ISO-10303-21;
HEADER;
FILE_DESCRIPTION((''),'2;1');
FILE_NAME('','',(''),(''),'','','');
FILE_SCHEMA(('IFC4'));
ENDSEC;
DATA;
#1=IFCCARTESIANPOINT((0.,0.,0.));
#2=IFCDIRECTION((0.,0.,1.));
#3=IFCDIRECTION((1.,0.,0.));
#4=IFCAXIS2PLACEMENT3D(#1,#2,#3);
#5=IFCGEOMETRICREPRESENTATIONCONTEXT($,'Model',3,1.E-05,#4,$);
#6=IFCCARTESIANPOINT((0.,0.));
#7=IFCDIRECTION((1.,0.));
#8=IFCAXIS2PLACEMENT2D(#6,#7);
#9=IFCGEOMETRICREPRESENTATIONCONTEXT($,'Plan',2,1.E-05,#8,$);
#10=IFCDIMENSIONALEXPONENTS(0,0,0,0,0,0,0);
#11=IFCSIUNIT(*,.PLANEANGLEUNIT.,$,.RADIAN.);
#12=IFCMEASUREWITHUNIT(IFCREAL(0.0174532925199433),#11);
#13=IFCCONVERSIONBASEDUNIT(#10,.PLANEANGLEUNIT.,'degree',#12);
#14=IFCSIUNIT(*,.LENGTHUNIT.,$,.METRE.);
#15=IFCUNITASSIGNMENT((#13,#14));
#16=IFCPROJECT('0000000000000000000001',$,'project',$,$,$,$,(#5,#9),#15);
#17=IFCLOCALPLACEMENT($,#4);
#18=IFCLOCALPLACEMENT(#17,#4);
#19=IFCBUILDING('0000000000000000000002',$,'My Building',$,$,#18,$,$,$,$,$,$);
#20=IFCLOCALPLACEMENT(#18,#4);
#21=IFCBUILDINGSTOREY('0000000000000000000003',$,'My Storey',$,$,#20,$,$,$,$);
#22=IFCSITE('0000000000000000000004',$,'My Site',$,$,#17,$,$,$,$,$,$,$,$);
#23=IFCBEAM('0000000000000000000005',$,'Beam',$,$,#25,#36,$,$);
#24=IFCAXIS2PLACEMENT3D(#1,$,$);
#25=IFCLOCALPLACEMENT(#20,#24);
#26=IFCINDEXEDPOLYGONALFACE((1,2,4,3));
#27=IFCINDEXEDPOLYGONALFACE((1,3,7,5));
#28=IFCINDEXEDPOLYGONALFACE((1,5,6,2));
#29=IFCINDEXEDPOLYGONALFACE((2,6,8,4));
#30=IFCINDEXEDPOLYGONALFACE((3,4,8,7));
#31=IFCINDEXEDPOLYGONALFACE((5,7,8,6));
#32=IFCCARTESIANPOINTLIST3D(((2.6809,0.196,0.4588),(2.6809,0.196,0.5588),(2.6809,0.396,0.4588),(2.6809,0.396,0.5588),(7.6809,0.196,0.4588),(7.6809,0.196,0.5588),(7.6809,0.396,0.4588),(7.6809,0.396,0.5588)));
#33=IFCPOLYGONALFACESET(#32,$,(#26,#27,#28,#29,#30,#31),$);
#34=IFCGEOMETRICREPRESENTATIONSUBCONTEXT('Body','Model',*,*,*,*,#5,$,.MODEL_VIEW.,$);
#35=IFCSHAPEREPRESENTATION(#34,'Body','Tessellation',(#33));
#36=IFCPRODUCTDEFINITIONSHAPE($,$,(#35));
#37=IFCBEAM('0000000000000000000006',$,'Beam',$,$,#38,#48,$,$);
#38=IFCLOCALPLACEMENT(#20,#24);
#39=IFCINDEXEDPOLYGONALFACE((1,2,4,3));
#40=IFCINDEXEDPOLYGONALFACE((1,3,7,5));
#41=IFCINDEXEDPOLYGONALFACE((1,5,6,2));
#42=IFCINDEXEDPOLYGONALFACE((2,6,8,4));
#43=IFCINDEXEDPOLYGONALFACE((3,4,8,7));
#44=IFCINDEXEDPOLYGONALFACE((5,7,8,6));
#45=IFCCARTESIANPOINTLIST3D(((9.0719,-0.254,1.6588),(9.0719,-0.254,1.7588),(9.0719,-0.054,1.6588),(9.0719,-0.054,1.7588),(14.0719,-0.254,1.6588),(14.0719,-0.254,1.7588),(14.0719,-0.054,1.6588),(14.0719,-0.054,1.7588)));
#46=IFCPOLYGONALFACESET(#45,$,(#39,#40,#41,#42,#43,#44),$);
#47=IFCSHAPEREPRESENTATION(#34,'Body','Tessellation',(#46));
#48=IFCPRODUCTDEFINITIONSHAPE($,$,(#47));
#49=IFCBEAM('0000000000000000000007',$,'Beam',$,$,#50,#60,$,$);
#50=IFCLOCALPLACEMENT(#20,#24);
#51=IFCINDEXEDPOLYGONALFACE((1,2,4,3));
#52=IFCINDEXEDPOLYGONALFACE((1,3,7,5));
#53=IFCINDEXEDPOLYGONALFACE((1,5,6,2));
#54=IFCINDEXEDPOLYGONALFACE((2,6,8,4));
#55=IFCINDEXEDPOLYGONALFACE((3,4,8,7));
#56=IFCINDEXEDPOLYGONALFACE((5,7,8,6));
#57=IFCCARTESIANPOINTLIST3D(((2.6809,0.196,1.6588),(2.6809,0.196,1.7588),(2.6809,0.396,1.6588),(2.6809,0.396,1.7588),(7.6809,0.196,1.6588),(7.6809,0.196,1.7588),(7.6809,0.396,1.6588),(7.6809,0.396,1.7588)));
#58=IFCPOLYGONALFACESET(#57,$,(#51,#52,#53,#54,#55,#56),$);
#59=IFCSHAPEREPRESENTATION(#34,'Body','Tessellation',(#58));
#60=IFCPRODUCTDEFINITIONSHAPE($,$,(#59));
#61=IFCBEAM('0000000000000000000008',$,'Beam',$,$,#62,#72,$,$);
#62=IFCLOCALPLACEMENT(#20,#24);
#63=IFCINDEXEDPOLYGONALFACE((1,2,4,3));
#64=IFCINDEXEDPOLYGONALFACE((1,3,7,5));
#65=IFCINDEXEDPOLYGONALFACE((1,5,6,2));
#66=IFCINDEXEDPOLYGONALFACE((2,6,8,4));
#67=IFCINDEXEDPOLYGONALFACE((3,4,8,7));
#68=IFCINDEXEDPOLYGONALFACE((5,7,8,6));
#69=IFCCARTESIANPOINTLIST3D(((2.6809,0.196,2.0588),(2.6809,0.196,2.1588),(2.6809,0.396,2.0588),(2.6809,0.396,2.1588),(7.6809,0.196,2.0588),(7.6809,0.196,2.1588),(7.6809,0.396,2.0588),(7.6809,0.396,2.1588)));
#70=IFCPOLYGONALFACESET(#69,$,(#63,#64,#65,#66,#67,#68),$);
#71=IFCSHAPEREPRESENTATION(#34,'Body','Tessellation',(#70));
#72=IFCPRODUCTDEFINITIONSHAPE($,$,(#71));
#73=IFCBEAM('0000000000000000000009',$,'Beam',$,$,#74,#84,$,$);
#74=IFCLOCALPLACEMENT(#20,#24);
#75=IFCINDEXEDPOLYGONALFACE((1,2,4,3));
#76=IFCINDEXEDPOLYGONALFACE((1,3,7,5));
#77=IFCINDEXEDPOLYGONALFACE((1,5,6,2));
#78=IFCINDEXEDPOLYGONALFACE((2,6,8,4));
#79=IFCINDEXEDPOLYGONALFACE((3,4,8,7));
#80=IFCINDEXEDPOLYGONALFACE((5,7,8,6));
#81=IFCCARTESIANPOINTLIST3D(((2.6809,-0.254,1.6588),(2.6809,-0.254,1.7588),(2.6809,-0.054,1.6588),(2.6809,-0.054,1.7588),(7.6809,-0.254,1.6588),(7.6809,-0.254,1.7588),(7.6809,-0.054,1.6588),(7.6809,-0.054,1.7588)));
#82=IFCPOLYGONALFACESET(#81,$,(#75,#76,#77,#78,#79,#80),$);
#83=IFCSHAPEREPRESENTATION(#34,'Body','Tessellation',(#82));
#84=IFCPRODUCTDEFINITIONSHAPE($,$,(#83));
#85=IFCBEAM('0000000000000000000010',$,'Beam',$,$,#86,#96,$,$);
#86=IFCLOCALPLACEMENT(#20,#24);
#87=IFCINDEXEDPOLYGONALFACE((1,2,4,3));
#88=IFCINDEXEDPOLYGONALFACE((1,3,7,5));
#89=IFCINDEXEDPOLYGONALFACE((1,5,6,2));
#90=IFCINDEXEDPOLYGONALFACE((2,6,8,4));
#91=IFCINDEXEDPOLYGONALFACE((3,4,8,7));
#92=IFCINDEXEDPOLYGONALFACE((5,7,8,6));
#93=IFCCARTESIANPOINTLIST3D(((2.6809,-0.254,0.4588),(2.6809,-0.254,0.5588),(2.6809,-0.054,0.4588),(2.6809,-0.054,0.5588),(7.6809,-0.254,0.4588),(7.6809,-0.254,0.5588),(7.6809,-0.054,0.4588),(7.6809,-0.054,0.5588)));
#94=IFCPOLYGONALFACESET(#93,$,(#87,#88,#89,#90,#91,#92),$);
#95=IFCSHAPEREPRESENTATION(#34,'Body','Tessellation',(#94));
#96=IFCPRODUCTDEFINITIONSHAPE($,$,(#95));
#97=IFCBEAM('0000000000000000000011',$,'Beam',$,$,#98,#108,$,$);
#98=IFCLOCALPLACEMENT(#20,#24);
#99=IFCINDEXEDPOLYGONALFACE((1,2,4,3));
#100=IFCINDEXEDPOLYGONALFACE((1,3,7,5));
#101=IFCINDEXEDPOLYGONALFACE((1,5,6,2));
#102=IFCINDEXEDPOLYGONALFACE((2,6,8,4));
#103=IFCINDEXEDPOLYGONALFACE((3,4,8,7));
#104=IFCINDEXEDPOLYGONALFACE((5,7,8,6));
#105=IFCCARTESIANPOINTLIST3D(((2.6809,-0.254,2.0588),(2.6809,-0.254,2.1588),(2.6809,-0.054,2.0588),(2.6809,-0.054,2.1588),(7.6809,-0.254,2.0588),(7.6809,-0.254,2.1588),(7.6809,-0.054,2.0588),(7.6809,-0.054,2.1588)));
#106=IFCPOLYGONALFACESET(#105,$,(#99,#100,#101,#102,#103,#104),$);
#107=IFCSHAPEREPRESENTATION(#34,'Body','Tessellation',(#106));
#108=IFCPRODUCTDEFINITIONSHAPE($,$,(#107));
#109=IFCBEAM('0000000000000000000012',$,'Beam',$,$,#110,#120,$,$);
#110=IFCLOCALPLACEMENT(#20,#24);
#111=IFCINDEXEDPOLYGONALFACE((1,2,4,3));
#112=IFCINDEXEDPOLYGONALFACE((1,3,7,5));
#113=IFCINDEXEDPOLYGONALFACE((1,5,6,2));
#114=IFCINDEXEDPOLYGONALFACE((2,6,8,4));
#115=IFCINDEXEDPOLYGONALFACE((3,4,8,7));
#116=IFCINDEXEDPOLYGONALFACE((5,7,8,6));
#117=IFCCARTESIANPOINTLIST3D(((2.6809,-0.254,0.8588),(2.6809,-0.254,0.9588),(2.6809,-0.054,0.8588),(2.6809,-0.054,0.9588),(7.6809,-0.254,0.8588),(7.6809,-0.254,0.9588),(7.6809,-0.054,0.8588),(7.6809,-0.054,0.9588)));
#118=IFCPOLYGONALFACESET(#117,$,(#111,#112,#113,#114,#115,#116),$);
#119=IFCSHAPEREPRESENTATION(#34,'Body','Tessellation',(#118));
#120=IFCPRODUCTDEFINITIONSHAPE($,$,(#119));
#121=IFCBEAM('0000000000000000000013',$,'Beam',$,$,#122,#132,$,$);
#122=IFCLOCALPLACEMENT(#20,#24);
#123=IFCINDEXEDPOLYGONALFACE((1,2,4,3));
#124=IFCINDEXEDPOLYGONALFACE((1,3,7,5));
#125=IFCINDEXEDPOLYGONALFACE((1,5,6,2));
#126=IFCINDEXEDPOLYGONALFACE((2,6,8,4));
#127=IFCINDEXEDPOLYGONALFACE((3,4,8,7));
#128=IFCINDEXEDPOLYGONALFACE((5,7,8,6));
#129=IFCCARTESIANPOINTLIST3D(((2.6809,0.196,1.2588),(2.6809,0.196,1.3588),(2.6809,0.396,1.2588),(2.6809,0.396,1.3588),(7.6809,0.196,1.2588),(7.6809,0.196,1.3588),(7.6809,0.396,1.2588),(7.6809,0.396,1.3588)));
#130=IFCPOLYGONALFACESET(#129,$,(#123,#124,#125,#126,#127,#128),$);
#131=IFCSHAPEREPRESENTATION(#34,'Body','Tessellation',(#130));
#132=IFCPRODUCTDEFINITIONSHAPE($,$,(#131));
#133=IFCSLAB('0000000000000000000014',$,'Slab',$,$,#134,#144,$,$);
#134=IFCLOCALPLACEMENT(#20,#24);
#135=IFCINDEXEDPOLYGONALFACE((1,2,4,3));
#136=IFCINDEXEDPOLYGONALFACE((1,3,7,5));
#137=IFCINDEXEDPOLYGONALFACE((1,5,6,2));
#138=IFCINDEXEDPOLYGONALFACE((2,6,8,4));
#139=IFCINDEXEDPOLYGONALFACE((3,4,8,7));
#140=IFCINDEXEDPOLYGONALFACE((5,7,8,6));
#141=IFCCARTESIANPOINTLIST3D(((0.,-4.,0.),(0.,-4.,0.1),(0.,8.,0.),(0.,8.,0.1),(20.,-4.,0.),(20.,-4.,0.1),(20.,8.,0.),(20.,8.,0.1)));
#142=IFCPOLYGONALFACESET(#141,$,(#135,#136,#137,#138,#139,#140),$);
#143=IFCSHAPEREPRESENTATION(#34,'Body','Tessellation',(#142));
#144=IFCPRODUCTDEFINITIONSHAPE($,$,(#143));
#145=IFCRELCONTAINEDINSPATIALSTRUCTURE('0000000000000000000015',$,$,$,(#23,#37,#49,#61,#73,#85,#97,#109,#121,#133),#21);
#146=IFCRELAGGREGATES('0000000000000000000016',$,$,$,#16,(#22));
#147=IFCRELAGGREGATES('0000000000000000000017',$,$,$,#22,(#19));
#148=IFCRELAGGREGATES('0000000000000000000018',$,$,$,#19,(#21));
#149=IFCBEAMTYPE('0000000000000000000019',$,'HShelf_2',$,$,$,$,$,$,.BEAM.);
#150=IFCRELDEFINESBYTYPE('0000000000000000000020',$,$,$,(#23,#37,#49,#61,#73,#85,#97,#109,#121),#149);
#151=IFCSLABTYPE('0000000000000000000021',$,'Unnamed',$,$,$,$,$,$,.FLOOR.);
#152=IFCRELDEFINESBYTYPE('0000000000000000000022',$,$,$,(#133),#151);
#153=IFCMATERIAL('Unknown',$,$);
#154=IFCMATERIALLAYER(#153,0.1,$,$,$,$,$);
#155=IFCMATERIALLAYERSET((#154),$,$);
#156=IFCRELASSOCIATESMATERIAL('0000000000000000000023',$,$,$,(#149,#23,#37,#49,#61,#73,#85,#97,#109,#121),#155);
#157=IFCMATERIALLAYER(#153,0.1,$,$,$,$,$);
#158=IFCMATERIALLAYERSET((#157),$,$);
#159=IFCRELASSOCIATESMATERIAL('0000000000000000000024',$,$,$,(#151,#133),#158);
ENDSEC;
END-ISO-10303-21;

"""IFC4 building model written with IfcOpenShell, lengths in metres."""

from ifc_helpers import new_model, entity, si_unit, converted_unit, frame, origin_with_axes, origin_2d_with_axis, place, context, subcontext, project, spatial, indexed_curve, outline, extrude, material, layer, layer_set, layer_usage, type_object, element, save


model = new_model("IFC4")

# Units and contexts
model_context = context("Model", 3, precision=1e-05, world=origin_with_axes())
plan_context = context("Plan", 2, precision=1e-05, world=origin_2d_with_axis())
body_context_1 = subcontext(model_context, "Body", "Model", "MODEL_VIEW")
ifc_project = project(units=[converted_unit("PLANEANGLEUNIT", "degree", entity("IfcReal", 0.0174532925199433), si_unit("PLANEANGLEUNIT", "RADIAN"), dimensions=[0, 0, 0, 0, 0, 0, 0]), si_unit("LENGTHUNIT", "METRE")], contexts=[model_context, plan_context])

# Site, building, storey
site_placement = place(None, origin_with_axes())
site = spatial("IfcSite", under=ifc_project, at=site_placement, Name="My Site")
building_placement = place(site_placement, origin_with_axes())
building = spatial("IfcBuilding", under=site, at=building_placement, Name="My Building")
storey_placement = place(building_placement, origin_with_axes())
storey = spatial("IfcBuildingStorey", under=building, at=storey_placement, Name="My Storey")

# Shared definitions
ifc_material = material(Name="Unknown")

# Beams
ifc_layer_1 = layer(ifc_material, 0.1)
ifc_layer_set_1 = layer_set([ifc_layer_1])
beam_type_1 = type_object("IfcBeamType", Name="HShelf_2", PredefinedType="BEAM", material=ifc_layer_set_1)
ifc_layer_usage_1 = layer_usage(ifc_layer_set_1, "AXIS3", "POSITIVE", -0.1)
beam_1_placement = place(storey_placement, frame((2.6809, 0.396, 0.5588), z_axis=(0.0, 0.0, 1.0), x_axis=(1.0, 0.0, 0.0)))
element("IfcBeam", 1, at=beam_1_placement, inside=storey, type_object=beam_type_1, material=ifc_layer_usage_1, Name="Beam", context=body_context_1, shape_type="SweptSolid", body=[
    extrude(outline(indexed_curve([(0.0, 0.0), (0.0, -0.2), (5.0, -0.2), (5.0, 0.0), (0.0, 0.0)])), frame((0.0, 0.0, -0.1), z_axis=(0.0, 0.0, 1.0), x_axis=(1.0, 0.0, 0.0)), (0.0, 0.0, 1.0), 0.1),
])
ifc_layer_usage_2 = layer_usage(ifc_layer_set_1, "AXIS3", "POSITIVE", -0.1)
beam_2_placement = place(storey_placement, frame((9.0719, -0.054, 1.7588), z_axis=(0.0, 0.0, 1.0), x_axis=(1.0, 0.0, 0.0)))
element("IfcBeam", 2, at=beam_2_placement, inside=storey, type_object=beam_type_1, material=ifc_layer_usage_2, Name="Beam", context=body_context_1, shape_type="SweptSolid", body=[
    extrude(outline(indexed_curve([(0.0, 0.0), (0.0, -0.2), (5.0, -0.2), (5.0, 0.0), (0.0, 0.0)])), frame((0.0, 0.0, -0.1), z_axis=(0.0, 0.0, 1.0), x_axis=(1.0, 0.0, 0.0)), (0.0, 0.0, 1.0), 0.1),
])
ifc_layer_usage_3 = layer_usage(ifc_layer_set_1, "AXIS3", "POSITIVE", -0.1)
beam_3_placement = place(storey_placement, frame((2.6809, 0.396, 1.7588), z_axis=(0.0, 0.0, 1.0), x_axis=(1.0, 0.0, 0.0)))
element("IfcBeam", 3, at=beam_3_placement, inside=storey, type_object=beam_type_1, material=ifc_layer_usage_3, Name="Beam", context=body_context_1, shape_type="SweptSolid", body=[
    extrude(outline(indexed_curve([(0.0, 0.0), (0.0, -0.2), (5.0, -0.2), (5.0, 0.0), (0.0, 0.0)])), frame((0.0, 0.0, -0.1), z_axis=(0.0, 0.0, 1.0), x_axis=(1.0, 0.0, 0.0)), (0.0, 0.0, 1.0), 0.1),
])
ifc_layer_usage_4 = layer_usage(ifc_layer_set_1, "AXIS3", "POSITIVE", -0.1)
beam_4_placement = place(storey_placement, frame((2.6809, 0.396, 2.1588), z_axis=(0.0, 0.0, 1.0), x_axis=(1.0, 0.0, 0.0)))
element("IfcBeam", 4, at=beam_4_placement, inside=storey, type_object=beam_type_1, material=ifc_layer_usage_4, Name="Beam", context=body_context_1, shape_type="SweptSolid", body=[
    extrude(outline(indexed_curve([(0.0, 0.0), (0.0, -0.2), (5.0, -0.2), (5.0, 0.0), (0.0, 0.0)])), frame((0.0, 0.0, -0.1), z_axis=(0.0, 0.0, 1.0), x_axis=(1.0, 0.0, 0.0)), (0.0, 0.0, 1.0), 0.1),
])
ifc_layer_usage_5 = layer_usage(ifc_layer_set_1, "AXIS3", "POSITIVE", -0.1)
beam_5_placement = place(storey_placement, frame((2.6809, -0.054, 1.7588), z_axis=(0.0, 0.0, 1.0), x_axis=(1.0, 0.0, 0.0)))
element("IfcBeam", 5, at=beam_5_placement, inside=storey, type_object=beam_type_1, material=ifc_layer_usage_5, Name="Beam", context=body_context_1, shape_type="SweptSolid", body=[
    extrude(outline(indexed_curve([(0.0, 0.0), (0.0, -0.2), (5.0, -0.2), (5.0, 0.0), (0.0, 0.0)])), frame((0.0, 0.0, -0.1), z_axis=(0.0, 0.0, 1.0), x_axis=(1.0, 0.0, 0.0)), (0.0, 0.0, 1.0), 0.1),
])
ifc_layer_usage_6 = layer_usage(ifc_layer_set_1, "AXIS3", "POSITIVE", -0.1)
beam_6_placement = place(storey_placement, frame((2.6809, -0.054, 0.5588), z_axis=(0.0, 0.0, 1.0), x_axis=(1.0, 0.0, 0.0)))
element("IfcBeam", 6, at=beam_6_placement, inside=storey, type_object=beam_type_1, material=ifc_layer_usage_6, Name="Beam", context=body_context_1, shape_type="SweptSolid", body=[
    extrude(outline(indexed_curve([(0.0, 0.0), (0.0, -0.2), (5.0, -0.2), (5.0, 0.0), (0.0, 0.0)])), frame((0.0, 0.0, -0.1), z_axis=(0.0, 0.0, 1.0), x_axis=(1.0, 0.0, 0.0)), (0.0, 0.0, 1.0), 0.1),
])
ifc_layer_usage_7 = layer_usage(ifc_layer_set_1, "AXIS3", "POSITIVE", -0.1)
beam_7_placement = place(storey_placement, frame((2.6809, -0.054, 2.1588), z_axis=(0.0, 0.0, 1.0), x_axis=(1.0, 0.0, 0.0)))
element("IfcBeam", 7, at=beam_7_placement, inside=storey, type_object=beam_type_1, material=ifc_layer_usage_7, Name="Beam", context=body_context_1, shape_type="SweptSolid", body=[
    extrude(outline(indexed_curve([(0.0, 0.0), (0.0, -0.2), (5.0, -0.2), (5.0, 0.0), (0.0, 0.0)])), frame((0.0, 0.0, -0.1), z_axis=(0.0, 0.0, 1.0), x_axis=(1.0, 0.0, 0.0)), (0.0, 0.0, 1.0), 0.1),
])
ifc_layer_usage_8 = layer_usage(ifc_layer_set_1, "AXIS3", "POSITIVE", -0.1)
beam_8_placement = place(storey_placement, frame((2.6809, -0.054, 0.9588), z_axis=(0.0, 0.0, 1.0), x_axis=(1.0, 0.0, 0.0)))
element("IfcBeam", 8, at=beam_8_placement, inside=storey, type_object=beam_type_1, material=ifc_layer_usage_8, Name="Beam", context=body_context_1, shape_type="SweptSolid", body=[
    extrude(outline(indexed_curve([(0.0, 0.0), (0.0, -0.2), (5.0, -0.2), (5.0, 0.0), (0.0, 0.0)])), frame((0.0, 0.0, -0.1), z_axis=(0.0, 0.0, 1.0), x_axis=(1.0, 0.0, 0.0)), (0.0, 0.0, 1.0), 0.1),
])
ifc_layer_usage_9 = layer_usage(ifc_layer_set_1, "AXIS3", "POSITIVE", -0.1)
beam_9_placement = place(storey_placement, frame((2.6809, 0.396, 1.3588), z_axis=(0.0, 0.0, 1.0), x_axis=(1.0, 0.0, 0.0)))
element("IfcBeam", 9, at=beam_9_placement, inside=storey, type_object=beam_type_1, material=ifc_layer_usage_9, Name="Beam", context=body_context_1, shape_type="SweptSolid", body=[
    extrude(outline(indexed_curve([(0.0, 0.0), (0.0, -0.2), (5.0, -0.2), (5.0, 0.0), (0.0, 0.0)])), frame((0.0, 0.0, -0.1), z_axis=(0.0, 0.0, 1.0), x_axis=(1.0, 0.0, 0.0)), (0.0, 0.0, 1.0), 0.1),
])

# Slab
ifc_layer_2 = layer(ifc_material, 0.1)
ifc_layer_set_2 = layer_set([ifc_layer_2])
ifc_layer_usage_10 = layer_usage(ifc_layer_set_2, "AXIS3", "POSITIVE", -0.1)
slab_type = type_object("IfcSlabType", Name="Unnamed", PredefinedType="FLOOR", material=ifc_layer_set_2)
slab_placement = place(storey_placement, frame((0.0, -4.0, 0.1), z_axis=(0.0, 0.0, 1.0), x_axis=(1.0, 0.0, 0.0)))
element("IfcSlab", 10, at=slab_placement, inside=storey, type_object=slab_type, material=ifc_layer_usage_10, Name="Slab", context=body_context_1, shape_type="SweptSolid", body=[
    extrude(outline(indexed_curve([(0.0, 0.0), (20.0, 0.0), (20.0, 12.0), (0.0, 12.0), (0.0, 0.0)])), frame((0.0, 0.0, -0.1), z_axis=(0.0, 0.0, 1.0), x_axis=(1.0, 0.0, 0.0)), (0.0, 0.0, 1.0), 0.1),
])

save(model, "model.ifc")
